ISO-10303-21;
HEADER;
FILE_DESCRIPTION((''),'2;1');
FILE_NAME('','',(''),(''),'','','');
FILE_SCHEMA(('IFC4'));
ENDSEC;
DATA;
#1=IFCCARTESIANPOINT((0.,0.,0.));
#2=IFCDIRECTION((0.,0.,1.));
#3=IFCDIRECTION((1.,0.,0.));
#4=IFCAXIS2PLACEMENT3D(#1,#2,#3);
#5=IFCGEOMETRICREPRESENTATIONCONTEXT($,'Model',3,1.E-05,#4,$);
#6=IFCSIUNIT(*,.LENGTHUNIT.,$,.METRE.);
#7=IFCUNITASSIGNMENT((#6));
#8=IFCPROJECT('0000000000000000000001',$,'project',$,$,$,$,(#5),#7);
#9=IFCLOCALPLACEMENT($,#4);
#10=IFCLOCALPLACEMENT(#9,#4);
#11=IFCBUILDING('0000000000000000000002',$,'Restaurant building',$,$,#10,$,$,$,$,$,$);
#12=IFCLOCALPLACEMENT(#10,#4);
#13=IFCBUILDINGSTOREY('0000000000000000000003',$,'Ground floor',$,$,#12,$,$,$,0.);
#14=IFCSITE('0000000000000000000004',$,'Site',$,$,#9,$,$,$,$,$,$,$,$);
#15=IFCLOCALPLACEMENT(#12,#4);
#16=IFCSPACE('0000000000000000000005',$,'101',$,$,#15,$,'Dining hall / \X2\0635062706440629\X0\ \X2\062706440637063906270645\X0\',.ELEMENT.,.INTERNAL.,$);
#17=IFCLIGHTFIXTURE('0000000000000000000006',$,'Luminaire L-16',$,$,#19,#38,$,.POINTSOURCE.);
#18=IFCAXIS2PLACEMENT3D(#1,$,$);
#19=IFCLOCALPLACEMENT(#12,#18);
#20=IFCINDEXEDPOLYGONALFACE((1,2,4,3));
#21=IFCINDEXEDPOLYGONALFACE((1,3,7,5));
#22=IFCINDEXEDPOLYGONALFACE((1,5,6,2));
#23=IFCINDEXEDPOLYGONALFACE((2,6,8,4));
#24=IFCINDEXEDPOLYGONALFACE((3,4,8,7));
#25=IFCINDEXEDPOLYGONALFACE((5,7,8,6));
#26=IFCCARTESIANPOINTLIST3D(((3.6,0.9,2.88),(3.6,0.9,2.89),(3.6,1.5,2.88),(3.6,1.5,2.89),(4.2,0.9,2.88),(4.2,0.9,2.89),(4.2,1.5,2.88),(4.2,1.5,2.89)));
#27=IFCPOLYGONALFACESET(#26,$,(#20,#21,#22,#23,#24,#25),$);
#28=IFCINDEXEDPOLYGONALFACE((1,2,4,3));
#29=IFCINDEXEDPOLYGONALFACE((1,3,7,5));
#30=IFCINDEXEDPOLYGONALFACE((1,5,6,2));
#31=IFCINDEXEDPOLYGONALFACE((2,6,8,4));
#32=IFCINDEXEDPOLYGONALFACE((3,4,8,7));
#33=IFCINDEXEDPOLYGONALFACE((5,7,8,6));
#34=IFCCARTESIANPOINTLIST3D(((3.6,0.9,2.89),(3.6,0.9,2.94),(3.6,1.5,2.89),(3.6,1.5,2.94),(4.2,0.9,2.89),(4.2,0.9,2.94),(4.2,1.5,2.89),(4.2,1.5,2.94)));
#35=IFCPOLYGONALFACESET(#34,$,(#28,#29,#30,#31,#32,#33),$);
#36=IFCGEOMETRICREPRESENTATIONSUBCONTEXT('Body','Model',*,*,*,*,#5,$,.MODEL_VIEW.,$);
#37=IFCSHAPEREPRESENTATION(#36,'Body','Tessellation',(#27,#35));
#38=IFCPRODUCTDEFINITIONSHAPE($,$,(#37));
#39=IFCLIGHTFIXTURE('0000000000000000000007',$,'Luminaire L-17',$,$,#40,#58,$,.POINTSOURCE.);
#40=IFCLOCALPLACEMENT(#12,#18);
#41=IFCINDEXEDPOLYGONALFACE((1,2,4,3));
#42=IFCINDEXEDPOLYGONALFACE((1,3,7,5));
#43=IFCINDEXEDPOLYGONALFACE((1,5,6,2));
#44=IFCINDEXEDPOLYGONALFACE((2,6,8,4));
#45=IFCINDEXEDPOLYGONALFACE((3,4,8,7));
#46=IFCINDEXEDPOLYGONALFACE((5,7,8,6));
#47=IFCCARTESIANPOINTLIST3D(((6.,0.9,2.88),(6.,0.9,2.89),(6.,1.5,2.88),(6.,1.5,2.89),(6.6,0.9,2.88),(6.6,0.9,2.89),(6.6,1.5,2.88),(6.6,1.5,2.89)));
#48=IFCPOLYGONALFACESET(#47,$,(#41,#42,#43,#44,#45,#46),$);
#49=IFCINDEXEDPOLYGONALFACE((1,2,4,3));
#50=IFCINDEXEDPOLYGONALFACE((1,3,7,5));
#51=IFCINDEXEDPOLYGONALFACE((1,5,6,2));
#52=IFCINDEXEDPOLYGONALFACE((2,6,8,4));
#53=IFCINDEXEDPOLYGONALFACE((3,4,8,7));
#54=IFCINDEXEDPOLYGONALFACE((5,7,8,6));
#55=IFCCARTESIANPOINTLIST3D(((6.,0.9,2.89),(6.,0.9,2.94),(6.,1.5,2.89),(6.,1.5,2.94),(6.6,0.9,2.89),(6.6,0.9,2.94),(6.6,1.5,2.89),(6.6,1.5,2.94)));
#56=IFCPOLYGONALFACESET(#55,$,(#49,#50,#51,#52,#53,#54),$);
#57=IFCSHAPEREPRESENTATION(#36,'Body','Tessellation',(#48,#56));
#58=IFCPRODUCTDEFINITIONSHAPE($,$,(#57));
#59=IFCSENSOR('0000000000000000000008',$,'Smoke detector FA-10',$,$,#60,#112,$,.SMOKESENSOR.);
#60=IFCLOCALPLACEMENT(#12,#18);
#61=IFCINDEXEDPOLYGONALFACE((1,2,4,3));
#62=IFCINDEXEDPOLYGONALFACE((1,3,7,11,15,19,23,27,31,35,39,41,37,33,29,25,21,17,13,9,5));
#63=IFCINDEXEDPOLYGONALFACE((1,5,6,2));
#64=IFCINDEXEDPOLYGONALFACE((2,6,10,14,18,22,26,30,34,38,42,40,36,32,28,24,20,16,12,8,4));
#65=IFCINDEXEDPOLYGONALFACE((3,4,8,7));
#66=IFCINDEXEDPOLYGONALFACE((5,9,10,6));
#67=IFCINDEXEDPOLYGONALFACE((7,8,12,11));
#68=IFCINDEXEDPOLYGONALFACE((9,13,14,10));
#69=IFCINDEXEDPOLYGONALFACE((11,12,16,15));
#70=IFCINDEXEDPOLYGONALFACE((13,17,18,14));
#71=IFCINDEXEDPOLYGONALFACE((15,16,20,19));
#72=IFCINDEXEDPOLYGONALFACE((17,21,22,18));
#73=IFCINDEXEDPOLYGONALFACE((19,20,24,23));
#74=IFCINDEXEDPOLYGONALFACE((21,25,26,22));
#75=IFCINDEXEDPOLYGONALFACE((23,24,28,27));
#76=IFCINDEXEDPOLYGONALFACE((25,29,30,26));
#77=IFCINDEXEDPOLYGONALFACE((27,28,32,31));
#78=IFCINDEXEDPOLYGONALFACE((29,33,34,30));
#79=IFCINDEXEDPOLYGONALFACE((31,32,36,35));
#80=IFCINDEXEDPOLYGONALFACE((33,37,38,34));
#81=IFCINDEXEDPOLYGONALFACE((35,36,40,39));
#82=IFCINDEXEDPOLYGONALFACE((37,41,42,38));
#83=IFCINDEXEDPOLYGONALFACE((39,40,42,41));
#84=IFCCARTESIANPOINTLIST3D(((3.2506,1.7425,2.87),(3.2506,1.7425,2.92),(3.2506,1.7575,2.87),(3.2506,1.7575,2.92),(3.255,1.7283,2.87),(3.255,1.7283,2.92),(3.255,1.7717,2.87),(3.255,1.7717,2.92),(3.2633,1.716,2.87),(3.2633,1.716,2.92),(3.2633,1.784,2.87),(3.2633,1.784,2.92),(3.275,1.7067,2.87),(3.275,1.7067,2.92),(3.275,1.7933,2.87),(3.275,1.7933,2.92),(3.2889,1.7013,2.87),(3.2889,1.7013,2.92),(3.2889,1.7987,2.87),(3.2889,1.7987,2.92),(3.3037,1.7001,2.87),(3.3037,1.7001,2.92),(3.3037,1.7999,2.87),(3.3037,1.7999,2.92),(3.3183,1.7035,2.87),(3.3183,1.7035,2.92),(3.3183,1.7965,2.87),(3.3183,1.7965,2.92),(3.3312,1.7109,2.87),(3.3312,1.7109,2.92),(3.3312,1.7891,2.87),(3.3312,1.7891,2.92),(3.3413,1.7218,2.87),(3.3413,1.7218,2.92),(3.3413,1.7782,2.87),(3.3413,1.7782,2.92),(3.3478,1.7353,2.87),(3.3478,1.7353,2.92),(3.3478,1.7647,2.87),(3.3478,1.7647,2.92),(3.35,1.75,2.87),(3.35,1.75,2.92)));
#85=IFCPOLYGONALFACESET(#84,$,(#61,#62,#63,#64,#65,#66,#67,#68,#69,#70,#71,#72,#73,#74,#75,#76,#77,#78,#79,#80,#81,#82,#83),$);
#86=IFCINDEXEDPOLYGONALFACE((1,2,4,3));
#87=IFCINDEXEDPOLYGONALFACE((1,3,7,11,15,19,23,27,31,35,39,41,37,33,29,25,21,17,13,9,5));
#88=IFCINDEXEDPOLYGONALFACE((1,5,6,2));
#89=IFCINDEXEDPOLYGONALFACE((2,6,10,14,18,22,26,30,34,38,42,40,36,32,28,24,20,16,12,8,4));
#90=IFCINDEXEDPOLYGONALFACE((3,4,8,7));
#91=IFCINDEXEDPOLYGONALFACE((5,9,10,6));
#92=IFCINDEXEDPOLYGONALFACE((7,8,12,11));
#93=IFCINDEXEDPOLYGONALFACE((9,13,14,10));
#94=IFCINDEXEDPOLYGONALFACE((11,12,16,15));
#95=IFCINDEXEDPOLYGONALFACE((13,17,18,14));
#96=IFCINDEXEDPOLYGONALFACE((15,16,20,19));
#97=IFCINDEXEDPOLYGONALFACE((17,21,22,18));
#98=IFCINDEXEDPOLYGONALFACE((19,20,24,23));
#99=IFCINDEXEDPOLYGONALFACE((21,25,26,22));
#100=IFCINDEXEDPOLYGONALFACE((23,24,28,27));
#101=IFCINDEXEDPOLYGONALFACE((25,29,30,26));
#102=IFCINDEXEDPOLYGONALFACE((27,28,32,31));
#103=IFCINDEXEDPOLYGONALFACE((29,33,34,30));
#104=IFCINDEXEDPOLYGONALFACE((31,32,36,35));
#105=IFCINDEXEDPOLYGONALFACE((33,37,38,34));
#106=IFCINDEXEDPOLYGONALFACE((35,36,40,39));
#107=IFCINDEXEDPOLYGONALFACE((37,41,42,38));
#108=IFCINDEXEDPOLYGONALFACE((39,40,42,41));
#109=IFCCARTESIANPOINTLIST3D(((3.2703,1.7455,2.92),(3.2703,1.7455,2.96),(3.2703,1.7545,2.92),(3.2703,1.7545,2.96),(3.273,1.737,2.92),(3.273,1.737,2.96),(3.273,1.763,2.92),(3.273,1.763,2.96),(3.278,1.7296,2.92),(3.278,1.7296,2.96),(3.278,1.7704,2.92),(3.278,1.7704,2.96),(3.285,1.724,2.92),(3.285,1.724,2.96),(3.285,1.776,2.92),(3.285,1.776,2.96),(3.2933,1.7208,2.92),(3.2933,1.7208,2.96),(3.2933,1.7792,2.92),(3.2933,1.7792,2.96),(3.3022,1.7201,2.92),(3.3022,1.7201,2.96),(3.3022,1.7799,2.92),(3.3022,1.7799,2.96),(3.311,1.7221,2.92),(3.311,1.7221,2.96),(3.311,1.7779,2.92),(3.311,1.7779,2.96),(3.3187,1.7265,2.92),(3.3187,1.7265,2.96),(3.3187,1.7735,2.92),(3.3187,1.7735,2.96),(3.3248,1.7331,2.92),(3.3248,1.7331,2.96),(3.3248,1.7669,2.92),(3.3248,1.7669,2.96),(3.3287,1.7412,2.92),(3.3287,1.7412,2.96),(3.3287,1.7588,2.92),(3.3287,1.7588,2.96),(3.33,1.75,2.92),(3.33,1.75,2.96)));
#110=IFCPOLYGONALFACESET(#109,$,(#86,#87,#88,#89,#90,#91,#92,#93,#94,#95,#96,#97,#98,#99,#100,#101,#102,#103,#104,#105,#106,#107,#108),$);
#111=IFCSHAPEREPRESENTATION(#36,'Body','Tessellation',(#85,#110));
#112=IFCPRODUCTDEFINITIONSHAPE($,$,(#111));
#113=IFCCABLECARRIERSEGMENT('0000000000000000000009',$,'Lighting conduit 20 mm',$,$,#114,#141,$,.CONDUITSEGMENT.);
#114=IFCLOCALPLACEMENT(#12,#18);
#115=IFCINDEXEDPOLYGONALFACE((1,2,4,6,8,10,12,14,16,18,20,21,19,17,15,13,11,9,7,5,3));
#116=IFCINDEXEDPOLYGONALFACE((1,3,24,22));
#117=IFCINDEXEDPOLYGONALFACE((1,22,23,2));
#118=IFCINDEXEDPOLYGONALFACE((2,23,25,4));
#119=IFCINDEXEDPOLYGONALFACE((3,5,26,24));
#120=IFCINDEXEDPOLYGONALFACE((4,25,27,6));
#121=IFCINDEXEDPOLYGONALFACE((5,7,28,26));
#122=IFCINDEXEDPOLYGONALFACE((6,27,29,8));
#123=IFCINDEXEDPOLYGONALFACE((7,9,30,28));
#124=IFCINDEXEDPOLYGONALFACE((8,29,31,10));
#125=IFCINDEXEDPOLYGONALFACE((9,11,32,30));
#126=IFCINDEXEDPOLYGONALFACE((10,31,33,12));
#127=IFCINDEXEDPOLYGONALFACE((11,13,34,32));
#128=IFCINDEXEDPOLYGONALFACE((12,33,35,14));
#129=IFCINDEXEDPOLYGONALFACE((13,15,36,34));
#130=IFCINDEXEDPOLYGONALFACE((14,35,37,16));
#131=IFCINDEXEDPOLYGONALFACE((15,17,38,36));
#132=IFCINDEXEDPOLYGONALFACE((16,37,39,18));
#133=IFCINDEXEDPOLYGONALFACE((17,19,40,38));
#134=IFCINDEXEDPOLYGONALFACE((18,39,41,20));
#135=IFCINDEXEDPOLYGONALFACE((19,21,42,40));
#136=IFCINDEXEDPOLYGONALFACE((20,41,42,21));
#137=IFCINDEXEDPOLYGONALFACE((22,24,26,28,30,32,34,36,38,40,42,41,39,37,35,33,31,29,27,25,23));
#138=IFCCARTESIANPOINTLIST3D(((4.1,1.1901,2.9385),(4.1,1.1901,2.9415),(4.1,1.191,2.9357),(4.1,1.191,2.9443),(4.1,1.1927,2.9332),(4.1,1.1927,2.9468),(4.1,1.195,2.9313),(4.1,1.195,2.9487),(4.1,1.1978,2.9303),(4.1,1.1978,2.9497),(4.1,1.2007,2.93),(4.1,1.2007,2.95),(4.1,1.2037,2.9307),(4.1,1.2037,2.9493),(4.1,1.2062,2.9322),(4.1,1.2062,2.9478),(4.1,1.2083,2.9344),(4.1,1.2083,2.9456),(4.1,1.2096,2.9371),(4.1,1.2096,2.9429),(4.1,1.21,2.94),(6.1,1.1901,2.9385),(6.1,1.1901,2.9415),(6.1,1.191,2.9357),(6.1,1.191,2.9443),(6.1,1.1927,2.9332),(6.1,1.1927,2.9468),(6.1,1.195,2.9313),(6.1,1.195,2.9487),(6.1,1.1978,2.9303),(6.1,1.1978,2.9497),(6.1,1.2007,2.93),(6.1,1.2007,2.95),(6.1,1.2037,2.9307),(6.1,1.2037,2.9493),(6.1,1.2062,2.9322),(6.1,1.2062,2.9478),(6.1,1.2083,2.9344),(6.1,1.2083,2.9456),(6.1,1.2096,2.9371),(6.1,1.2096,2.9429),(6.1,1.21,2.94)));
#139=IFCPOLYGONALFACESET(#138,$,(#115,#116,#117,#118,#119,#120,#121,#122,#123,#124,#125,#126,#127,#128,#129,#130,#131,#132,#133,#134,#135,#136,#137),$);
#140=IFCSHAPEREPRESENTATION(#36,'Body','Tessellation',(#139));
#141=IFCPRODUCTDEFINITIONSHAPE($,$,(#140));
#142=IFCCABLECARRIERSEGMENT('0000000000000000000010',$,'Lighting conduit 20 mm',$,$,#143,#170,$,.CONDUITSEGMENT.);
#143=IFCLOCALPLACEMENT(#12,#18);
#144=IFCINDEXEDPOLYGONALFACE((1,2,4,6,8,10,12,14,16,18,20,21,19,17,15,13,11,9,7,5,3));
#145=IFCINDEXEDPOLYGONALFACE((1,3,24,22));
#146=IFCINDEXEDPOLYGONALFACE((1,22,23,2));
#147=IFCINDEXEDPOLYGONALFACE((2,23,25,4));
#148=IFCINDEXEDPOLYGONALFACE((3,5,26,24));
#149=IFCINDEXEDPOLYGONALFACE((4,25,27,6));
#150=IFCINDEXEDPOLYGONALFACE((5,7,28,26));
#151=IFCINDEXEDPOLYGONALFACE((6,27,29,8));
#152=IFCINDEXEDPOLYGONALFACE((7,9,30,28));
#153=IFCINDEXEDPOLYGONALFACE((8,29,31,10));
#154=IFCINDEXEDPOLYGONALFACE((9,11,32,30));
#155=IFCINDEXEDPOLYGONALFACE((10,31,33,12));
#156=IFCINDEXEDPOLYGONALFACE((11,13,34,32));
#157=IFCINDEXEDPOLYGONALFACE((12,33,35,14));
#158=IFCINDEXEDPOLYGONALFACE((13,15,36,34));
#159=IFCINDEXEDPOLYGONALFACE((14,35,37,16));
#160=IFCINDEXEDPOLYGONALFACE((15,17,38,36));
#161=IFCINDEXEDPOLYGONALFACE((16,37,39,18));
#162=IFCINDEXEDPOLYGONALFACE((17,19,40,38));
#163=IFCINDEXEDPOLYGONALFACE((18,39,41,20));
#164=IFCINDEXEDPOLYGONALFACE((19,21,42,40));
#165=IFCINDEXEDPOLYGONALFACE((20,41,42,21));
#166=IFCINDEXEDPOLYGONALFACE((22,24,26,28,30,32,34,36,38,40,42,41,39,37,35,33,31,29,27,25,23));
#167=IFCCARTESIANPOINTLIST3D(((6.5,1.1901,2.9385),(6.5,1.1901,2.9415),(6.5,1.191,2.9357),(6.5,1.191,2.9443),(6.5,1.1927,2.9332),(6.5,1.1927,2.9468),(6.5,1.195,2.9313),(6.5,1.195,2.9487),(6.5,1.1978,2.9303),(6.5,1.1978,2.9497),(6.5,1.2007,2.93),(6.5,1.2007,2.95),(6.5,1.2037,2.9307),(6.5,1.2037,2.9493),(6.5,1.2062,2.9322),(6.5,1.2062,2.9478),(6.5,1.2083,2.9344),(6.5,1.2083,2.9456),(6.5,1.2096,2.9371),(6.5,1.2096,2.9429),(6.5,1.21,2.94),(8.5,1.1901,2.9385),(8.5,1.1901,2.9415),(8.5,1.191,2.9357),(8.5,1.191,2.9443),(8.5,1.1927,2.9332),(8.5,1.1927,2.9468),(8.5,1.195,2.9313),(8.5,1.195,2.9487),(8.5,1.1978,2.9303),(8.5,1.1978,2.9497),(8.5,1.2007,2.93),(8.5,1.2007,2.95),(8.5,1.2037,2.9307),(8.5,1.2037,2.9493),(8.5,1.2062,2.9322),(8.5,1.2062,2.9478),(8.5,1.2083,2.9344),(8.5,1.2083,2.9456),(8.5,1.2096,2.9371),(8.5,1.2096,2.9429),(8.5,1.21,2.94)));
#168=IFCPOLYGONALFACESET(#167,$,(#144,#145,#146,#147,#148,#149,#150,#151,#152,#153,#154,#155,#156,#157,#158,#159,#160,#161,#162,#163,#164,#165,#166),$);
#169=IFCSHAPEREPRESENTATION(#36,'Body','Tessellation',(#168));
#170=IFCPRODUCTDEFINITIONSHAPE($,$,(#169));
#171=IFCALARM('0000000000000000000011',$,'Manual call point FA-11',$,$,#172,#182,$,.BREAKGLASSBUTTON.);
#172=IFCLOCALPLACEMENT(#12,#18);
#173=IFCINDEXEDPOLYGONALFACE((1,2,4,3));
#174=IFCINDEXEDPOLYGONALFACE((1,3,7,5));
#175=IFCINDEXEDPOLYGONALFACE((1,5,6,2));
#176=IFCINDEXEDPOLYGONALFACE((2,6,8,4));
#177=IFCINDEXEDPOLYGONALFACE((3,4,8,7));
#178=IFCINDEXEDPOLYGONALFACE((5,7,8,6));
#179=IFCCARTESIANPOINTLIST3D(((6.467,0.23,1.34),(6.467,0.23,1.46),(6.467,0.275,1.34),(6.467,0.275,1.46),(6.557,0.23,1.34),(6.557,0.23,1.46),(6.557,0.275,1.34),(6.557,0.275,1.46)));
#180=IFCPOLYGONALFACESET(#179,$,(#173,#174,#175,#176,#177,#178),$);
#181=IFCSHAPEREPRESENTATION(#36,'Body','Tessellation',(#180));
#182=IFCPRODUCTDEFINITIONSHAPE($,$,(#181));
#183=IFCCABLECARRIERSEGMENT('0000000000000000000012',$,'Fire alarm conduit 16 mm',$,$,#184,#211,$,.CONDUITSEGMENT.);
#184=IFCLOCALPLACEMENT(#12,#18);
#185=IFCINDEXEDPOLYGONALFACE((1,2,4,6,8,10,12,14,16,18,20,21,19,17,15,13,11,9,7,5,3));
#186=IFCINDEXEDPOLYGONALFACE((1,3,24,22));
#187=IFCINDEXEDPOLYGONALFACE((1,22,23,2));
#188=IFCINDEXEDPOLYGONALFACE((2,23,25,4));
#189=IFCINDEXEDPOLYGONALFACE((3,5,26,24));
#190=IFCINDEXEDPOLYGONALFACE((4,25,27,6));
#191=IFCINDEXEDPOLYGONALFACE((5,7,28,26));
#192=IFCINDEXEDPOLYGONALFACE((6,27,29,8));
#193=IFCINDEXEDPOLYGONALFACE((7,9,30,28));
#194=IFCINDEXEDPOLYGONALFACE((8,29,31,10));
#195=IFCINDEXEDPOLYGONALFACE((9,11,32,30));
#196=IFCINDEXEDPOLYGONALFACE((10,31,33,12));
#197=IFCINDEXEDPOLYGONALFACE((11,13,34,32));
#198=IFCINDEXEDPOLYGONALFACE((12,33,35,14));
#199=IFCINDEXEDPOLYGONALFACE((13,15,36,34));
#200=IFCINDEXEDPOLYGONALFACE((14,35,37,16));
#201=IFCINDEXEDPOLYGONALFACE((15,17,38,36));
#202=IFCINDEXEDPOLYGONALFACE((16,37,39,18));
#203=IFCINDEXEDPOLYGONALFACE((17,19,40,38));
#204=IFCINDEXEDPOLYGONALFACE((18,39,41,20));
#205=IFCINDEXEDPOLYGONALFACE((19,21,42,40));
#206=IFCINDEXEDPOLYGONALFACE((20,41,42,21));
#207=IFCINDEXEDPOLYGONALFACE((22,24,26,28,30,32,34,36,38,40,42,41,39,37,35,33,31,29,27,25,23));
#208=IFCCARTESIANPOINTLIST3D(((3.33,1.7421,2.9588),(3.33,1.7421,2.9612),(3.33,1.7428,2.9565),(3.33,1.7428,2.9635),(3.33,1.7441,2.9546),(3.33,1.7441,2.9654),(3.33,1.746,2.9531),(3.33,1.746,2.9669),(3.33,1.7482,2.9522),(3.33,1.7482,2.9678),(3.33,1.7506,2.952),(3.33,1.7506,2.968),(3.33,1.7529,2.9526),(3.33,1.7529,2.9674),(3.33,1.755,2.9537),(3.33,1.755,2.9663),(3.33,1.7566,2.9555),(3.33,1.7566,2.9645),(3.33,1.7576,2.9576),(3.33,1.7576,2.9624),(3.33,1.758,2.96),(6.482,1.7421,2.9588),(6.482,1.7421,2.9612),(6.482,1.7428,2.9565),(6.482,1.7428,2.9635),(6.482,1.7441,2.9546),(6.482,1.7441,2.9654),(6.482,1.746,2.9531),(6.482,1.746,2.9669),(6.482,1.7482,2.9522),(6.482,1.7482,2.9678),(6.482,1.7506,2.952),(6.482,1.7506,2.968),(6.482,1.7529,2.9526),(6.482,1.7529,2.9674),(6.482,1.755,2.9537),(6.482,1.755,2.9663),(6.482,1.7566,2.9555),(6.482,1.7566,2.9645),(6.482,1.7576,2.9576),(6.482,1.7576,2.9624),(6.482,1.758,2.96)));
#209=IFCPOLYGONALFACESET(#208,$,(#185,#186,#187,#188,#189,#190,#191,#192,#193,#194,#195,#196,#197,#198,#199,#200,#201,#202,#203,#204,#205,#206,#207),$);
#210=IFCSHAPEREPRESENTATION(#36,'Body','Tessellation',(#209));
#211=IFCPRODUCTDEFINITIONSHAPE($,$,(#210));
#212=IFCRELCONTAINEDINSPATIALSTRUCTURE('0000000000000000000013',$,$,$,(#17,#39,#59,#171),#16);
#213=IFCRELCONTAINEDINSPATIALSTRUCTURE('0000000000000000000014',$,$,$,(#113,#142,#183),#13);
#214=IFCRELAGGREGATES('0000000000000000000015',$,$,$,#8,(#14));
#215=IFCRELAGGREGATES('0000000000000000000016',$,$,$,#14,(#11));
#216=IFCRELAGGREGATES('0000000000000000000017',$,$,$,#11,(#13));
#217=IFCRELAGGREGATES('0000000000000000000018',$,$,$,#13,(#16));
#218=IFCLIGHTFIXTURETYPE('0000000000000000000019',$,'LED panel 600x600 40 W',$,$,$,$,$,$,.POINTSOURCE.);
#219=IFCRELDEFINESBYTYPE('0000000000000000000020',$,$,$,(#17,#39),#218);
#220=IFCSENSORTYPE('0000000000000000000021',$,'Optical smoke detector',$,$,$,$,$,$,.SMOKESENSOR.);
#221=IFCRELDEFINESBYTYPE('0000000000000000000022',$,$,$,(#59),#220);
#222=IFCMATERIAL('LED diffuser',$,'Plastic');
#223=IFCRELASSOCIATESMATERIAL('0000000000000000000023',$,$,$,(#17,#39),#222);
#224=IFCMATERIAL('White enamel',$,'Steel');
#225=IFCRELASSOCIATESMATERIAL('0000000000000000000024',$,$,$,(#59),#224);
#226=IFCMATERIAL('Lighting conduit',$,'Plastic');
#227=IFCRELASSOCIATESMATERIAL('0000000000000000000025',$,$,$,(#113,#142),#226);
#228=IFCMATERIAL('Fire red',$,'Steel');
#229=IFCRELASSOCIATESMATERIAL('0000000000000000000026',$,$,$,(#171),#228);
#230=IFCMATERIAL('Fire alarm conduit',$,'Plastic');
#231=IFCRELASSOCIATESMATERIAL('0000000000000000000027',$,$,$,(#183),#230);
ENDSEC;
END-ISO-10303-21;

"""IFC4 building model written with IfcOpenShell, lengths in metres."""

from ifc_helpers import new_model, si_unit, frame, origin, origin_with_axes, origin_2d, place, context, subcontext, project, spatial, rectangle, circle, extrude, source, transform, mapped, material, type_object, type_shapes, element, save


model = new_model("IFC4")

# Units and contexts
model_context = context("Model", 3, precision=1e-05, world=origin_with_axes())
body_context = subcontext(model_context, "Body", "Model", "MODEL_VIEW")
ifc_project = project(units=[si_unit("LENGTHUNIT", "METRE")], contexts=[model_context])

# Site, building, storey, space
site_placement = place(None, origin_with_axes())
site = spatial("IfcSite", under=ifc_project, at=site_placement, Name="Site")
building_placement = place(site_placement, origin_with_axes())
building = spatial("IfcBuilding", under=site, at=building_placement, Name="Restaurant building")
storey_placement = place(building_placement, origin_with_axes())
storey = spatial("IfcBuildingStorey", under=building, at=storey_placement, Name="Ground floor", Elevation=0.0)
space_placement = place(storey_placement, origin_with_axes())
space = spatial("IfcSpace", under=storey, at=space_placement, Name="101", LongName="Dining hall / صالة الطعام", CompositionType="ELEMENT", PredefinedType="INTERNAL")

# Light fixtures
ifc_material_1 = material(Name="LED diffuser", Category="Plastic")
light_fixture_type = type_object("IfcLightFixtureType", Name="LED panel 600x600 40 W", PredefinedType="POINTSOURCE")
shared_shape_1 = source(origin(), body_context, "Body", "SweptSolid", [
    extrude(rectangle(XDim=0.6, YDim=0.6, at=origin_2d()), frame((0.0, 0.0, -0.06)), (0.0, 0.0, 1.0), 0.01),
    extrude(rectangle(XDim=0.6, YDim=0.6, at=origin_2d()), frame((0.0, 0.0, -0.05)), (0.0, 0.0, 1.0), 0.05),
])
type_shapes(light_fixture_type, [shared_shape_1])
for number, where, name in (
    (1, (3.9, 1.2, 2.94), "Luminaire L-16"),
    (2, (6.3, 1.2, 2.94), "Luminaire L-17"),
):
    element("IfcLightFixture", number, at=place(storey_placement, frame(where)), inside=space, type_object=light_fixture_type, material=ifc_material_1, Name=name, PredefinedType="POINTSOURCE", context=body_context, shape_type="MappedRepresentation", body=[
        mapped(shared_shape_1, transform((0.0, 0.0, 0.0))),
    ])

# Sensor
ifc_material_2 = material(Name="White enamel", Category="Steel")
sensor_type = type_object("IfcSensorType", Name="Optical smoke detector", PredefinedType="SMOKESENSOR")
shared_shape_2 = source(origin(), body_context, "Body", "SweptSolid", [
    extrude(circle(Radius=0.05, at=origin_2d()), frame((0.0, 0.0, -0.09)), (0.0, 0.0, 1.0), 0.05),
    extrude(circle(Radius=0.03, at=origin_2d()), frame((0.0, 0.0, -0.04)), (0.0, 0.0, 1.0), 0.04),
])
type_shapes(sensor_type, [shared_shape_2])
sensor_placement = place(storey_placement, frame((3.3, 1.75, 2.96)))
element("IfcSensor", 3, at=sensor_placement, inside=space, type_object=sensor_type, material=ifc_material_2, Name="Smoke detector FA-10", PredefinedType="SMOKESENSOR", context=body_context, shape_type="MappedRepresentation", body=[
    mapped(shared_shape_2, transform((0.0, 0.0, 0.0))),
])

# Cable carrier segments
ifc_material_3 = material(Name="Lighting conduit", Category="Plastic")
for number, where, name in (
    (4, (4.1, 1.2, 2.94), "Lighting conduit 20 mm"),
    (5, (6.5, 1.2, 2.94), "Lighting conduit 20 mm"),
):
    element("IfcCableCarrierSegment", number, at=place(storey_placement, frame(where)), inside=storey, material=ifc_material_3, Name=name, PredefinedType="CONDUITSEGMENT", context=body_context, shape_type="SweptSolid", body=[
        extrude(circle(Radius=0.01, at=origin_2d()), frame((0.0, 0.0, 0.0), z_axis=(1.0, 0.0, 0.0), x_axis=(0.0, 1.0, 0.0)), (0.0, 0.0, 1.0), 2.0),
    ])

# Alarm
ifc_material_4 = material(Name="Fire red", Category="Steel")
alarm_placement = place(storey_placement, frame((6.512, 0.23, 1.4)))
element("IfcAlarm", 6, at=alarm_placement, inside=space, material=ifc_material_4, Name="Manual call point FA-11", PredefinedType="BREAKGLASSBUTTON", context=body_context, shape_type="SweptSolid", body=[
    extrude(rectangle(XDim=0.09, YDim=0.045, at=origin_2d()), frame((0.0, 0.0225, -0.06)), (0.0, 0.0, 1.0), 0.12),
])

# Cable carrier segment
ifc_material_5 = material(Name="Fire alarm conduit", Category="Plastic")
cable_carrier_segment_1_placement = place(storey_placement, frame((3.33, 1.75, 2.96)))
element("IfcCableCarrierSegment", 7, at=cable_carrier_segment_1_placement, inside=storey, material=ifc_material_5, Name="Fire alarm conduit 16 mm", PredefinedType="CONDUITSEGMENT", context=body_context, shape_type="SweptSolid", body=[
    extrude(circle(Radius=0.008, at=origin_2d()), frame((0.0, 0.0, 0.0), z_axis=(1.0, 0.0, 0.0), x_axis=(0.0, 1.0, 0.0)), (0.0, 0.0, 1.0), 3.152),
])

save(model, "model.ifc")
